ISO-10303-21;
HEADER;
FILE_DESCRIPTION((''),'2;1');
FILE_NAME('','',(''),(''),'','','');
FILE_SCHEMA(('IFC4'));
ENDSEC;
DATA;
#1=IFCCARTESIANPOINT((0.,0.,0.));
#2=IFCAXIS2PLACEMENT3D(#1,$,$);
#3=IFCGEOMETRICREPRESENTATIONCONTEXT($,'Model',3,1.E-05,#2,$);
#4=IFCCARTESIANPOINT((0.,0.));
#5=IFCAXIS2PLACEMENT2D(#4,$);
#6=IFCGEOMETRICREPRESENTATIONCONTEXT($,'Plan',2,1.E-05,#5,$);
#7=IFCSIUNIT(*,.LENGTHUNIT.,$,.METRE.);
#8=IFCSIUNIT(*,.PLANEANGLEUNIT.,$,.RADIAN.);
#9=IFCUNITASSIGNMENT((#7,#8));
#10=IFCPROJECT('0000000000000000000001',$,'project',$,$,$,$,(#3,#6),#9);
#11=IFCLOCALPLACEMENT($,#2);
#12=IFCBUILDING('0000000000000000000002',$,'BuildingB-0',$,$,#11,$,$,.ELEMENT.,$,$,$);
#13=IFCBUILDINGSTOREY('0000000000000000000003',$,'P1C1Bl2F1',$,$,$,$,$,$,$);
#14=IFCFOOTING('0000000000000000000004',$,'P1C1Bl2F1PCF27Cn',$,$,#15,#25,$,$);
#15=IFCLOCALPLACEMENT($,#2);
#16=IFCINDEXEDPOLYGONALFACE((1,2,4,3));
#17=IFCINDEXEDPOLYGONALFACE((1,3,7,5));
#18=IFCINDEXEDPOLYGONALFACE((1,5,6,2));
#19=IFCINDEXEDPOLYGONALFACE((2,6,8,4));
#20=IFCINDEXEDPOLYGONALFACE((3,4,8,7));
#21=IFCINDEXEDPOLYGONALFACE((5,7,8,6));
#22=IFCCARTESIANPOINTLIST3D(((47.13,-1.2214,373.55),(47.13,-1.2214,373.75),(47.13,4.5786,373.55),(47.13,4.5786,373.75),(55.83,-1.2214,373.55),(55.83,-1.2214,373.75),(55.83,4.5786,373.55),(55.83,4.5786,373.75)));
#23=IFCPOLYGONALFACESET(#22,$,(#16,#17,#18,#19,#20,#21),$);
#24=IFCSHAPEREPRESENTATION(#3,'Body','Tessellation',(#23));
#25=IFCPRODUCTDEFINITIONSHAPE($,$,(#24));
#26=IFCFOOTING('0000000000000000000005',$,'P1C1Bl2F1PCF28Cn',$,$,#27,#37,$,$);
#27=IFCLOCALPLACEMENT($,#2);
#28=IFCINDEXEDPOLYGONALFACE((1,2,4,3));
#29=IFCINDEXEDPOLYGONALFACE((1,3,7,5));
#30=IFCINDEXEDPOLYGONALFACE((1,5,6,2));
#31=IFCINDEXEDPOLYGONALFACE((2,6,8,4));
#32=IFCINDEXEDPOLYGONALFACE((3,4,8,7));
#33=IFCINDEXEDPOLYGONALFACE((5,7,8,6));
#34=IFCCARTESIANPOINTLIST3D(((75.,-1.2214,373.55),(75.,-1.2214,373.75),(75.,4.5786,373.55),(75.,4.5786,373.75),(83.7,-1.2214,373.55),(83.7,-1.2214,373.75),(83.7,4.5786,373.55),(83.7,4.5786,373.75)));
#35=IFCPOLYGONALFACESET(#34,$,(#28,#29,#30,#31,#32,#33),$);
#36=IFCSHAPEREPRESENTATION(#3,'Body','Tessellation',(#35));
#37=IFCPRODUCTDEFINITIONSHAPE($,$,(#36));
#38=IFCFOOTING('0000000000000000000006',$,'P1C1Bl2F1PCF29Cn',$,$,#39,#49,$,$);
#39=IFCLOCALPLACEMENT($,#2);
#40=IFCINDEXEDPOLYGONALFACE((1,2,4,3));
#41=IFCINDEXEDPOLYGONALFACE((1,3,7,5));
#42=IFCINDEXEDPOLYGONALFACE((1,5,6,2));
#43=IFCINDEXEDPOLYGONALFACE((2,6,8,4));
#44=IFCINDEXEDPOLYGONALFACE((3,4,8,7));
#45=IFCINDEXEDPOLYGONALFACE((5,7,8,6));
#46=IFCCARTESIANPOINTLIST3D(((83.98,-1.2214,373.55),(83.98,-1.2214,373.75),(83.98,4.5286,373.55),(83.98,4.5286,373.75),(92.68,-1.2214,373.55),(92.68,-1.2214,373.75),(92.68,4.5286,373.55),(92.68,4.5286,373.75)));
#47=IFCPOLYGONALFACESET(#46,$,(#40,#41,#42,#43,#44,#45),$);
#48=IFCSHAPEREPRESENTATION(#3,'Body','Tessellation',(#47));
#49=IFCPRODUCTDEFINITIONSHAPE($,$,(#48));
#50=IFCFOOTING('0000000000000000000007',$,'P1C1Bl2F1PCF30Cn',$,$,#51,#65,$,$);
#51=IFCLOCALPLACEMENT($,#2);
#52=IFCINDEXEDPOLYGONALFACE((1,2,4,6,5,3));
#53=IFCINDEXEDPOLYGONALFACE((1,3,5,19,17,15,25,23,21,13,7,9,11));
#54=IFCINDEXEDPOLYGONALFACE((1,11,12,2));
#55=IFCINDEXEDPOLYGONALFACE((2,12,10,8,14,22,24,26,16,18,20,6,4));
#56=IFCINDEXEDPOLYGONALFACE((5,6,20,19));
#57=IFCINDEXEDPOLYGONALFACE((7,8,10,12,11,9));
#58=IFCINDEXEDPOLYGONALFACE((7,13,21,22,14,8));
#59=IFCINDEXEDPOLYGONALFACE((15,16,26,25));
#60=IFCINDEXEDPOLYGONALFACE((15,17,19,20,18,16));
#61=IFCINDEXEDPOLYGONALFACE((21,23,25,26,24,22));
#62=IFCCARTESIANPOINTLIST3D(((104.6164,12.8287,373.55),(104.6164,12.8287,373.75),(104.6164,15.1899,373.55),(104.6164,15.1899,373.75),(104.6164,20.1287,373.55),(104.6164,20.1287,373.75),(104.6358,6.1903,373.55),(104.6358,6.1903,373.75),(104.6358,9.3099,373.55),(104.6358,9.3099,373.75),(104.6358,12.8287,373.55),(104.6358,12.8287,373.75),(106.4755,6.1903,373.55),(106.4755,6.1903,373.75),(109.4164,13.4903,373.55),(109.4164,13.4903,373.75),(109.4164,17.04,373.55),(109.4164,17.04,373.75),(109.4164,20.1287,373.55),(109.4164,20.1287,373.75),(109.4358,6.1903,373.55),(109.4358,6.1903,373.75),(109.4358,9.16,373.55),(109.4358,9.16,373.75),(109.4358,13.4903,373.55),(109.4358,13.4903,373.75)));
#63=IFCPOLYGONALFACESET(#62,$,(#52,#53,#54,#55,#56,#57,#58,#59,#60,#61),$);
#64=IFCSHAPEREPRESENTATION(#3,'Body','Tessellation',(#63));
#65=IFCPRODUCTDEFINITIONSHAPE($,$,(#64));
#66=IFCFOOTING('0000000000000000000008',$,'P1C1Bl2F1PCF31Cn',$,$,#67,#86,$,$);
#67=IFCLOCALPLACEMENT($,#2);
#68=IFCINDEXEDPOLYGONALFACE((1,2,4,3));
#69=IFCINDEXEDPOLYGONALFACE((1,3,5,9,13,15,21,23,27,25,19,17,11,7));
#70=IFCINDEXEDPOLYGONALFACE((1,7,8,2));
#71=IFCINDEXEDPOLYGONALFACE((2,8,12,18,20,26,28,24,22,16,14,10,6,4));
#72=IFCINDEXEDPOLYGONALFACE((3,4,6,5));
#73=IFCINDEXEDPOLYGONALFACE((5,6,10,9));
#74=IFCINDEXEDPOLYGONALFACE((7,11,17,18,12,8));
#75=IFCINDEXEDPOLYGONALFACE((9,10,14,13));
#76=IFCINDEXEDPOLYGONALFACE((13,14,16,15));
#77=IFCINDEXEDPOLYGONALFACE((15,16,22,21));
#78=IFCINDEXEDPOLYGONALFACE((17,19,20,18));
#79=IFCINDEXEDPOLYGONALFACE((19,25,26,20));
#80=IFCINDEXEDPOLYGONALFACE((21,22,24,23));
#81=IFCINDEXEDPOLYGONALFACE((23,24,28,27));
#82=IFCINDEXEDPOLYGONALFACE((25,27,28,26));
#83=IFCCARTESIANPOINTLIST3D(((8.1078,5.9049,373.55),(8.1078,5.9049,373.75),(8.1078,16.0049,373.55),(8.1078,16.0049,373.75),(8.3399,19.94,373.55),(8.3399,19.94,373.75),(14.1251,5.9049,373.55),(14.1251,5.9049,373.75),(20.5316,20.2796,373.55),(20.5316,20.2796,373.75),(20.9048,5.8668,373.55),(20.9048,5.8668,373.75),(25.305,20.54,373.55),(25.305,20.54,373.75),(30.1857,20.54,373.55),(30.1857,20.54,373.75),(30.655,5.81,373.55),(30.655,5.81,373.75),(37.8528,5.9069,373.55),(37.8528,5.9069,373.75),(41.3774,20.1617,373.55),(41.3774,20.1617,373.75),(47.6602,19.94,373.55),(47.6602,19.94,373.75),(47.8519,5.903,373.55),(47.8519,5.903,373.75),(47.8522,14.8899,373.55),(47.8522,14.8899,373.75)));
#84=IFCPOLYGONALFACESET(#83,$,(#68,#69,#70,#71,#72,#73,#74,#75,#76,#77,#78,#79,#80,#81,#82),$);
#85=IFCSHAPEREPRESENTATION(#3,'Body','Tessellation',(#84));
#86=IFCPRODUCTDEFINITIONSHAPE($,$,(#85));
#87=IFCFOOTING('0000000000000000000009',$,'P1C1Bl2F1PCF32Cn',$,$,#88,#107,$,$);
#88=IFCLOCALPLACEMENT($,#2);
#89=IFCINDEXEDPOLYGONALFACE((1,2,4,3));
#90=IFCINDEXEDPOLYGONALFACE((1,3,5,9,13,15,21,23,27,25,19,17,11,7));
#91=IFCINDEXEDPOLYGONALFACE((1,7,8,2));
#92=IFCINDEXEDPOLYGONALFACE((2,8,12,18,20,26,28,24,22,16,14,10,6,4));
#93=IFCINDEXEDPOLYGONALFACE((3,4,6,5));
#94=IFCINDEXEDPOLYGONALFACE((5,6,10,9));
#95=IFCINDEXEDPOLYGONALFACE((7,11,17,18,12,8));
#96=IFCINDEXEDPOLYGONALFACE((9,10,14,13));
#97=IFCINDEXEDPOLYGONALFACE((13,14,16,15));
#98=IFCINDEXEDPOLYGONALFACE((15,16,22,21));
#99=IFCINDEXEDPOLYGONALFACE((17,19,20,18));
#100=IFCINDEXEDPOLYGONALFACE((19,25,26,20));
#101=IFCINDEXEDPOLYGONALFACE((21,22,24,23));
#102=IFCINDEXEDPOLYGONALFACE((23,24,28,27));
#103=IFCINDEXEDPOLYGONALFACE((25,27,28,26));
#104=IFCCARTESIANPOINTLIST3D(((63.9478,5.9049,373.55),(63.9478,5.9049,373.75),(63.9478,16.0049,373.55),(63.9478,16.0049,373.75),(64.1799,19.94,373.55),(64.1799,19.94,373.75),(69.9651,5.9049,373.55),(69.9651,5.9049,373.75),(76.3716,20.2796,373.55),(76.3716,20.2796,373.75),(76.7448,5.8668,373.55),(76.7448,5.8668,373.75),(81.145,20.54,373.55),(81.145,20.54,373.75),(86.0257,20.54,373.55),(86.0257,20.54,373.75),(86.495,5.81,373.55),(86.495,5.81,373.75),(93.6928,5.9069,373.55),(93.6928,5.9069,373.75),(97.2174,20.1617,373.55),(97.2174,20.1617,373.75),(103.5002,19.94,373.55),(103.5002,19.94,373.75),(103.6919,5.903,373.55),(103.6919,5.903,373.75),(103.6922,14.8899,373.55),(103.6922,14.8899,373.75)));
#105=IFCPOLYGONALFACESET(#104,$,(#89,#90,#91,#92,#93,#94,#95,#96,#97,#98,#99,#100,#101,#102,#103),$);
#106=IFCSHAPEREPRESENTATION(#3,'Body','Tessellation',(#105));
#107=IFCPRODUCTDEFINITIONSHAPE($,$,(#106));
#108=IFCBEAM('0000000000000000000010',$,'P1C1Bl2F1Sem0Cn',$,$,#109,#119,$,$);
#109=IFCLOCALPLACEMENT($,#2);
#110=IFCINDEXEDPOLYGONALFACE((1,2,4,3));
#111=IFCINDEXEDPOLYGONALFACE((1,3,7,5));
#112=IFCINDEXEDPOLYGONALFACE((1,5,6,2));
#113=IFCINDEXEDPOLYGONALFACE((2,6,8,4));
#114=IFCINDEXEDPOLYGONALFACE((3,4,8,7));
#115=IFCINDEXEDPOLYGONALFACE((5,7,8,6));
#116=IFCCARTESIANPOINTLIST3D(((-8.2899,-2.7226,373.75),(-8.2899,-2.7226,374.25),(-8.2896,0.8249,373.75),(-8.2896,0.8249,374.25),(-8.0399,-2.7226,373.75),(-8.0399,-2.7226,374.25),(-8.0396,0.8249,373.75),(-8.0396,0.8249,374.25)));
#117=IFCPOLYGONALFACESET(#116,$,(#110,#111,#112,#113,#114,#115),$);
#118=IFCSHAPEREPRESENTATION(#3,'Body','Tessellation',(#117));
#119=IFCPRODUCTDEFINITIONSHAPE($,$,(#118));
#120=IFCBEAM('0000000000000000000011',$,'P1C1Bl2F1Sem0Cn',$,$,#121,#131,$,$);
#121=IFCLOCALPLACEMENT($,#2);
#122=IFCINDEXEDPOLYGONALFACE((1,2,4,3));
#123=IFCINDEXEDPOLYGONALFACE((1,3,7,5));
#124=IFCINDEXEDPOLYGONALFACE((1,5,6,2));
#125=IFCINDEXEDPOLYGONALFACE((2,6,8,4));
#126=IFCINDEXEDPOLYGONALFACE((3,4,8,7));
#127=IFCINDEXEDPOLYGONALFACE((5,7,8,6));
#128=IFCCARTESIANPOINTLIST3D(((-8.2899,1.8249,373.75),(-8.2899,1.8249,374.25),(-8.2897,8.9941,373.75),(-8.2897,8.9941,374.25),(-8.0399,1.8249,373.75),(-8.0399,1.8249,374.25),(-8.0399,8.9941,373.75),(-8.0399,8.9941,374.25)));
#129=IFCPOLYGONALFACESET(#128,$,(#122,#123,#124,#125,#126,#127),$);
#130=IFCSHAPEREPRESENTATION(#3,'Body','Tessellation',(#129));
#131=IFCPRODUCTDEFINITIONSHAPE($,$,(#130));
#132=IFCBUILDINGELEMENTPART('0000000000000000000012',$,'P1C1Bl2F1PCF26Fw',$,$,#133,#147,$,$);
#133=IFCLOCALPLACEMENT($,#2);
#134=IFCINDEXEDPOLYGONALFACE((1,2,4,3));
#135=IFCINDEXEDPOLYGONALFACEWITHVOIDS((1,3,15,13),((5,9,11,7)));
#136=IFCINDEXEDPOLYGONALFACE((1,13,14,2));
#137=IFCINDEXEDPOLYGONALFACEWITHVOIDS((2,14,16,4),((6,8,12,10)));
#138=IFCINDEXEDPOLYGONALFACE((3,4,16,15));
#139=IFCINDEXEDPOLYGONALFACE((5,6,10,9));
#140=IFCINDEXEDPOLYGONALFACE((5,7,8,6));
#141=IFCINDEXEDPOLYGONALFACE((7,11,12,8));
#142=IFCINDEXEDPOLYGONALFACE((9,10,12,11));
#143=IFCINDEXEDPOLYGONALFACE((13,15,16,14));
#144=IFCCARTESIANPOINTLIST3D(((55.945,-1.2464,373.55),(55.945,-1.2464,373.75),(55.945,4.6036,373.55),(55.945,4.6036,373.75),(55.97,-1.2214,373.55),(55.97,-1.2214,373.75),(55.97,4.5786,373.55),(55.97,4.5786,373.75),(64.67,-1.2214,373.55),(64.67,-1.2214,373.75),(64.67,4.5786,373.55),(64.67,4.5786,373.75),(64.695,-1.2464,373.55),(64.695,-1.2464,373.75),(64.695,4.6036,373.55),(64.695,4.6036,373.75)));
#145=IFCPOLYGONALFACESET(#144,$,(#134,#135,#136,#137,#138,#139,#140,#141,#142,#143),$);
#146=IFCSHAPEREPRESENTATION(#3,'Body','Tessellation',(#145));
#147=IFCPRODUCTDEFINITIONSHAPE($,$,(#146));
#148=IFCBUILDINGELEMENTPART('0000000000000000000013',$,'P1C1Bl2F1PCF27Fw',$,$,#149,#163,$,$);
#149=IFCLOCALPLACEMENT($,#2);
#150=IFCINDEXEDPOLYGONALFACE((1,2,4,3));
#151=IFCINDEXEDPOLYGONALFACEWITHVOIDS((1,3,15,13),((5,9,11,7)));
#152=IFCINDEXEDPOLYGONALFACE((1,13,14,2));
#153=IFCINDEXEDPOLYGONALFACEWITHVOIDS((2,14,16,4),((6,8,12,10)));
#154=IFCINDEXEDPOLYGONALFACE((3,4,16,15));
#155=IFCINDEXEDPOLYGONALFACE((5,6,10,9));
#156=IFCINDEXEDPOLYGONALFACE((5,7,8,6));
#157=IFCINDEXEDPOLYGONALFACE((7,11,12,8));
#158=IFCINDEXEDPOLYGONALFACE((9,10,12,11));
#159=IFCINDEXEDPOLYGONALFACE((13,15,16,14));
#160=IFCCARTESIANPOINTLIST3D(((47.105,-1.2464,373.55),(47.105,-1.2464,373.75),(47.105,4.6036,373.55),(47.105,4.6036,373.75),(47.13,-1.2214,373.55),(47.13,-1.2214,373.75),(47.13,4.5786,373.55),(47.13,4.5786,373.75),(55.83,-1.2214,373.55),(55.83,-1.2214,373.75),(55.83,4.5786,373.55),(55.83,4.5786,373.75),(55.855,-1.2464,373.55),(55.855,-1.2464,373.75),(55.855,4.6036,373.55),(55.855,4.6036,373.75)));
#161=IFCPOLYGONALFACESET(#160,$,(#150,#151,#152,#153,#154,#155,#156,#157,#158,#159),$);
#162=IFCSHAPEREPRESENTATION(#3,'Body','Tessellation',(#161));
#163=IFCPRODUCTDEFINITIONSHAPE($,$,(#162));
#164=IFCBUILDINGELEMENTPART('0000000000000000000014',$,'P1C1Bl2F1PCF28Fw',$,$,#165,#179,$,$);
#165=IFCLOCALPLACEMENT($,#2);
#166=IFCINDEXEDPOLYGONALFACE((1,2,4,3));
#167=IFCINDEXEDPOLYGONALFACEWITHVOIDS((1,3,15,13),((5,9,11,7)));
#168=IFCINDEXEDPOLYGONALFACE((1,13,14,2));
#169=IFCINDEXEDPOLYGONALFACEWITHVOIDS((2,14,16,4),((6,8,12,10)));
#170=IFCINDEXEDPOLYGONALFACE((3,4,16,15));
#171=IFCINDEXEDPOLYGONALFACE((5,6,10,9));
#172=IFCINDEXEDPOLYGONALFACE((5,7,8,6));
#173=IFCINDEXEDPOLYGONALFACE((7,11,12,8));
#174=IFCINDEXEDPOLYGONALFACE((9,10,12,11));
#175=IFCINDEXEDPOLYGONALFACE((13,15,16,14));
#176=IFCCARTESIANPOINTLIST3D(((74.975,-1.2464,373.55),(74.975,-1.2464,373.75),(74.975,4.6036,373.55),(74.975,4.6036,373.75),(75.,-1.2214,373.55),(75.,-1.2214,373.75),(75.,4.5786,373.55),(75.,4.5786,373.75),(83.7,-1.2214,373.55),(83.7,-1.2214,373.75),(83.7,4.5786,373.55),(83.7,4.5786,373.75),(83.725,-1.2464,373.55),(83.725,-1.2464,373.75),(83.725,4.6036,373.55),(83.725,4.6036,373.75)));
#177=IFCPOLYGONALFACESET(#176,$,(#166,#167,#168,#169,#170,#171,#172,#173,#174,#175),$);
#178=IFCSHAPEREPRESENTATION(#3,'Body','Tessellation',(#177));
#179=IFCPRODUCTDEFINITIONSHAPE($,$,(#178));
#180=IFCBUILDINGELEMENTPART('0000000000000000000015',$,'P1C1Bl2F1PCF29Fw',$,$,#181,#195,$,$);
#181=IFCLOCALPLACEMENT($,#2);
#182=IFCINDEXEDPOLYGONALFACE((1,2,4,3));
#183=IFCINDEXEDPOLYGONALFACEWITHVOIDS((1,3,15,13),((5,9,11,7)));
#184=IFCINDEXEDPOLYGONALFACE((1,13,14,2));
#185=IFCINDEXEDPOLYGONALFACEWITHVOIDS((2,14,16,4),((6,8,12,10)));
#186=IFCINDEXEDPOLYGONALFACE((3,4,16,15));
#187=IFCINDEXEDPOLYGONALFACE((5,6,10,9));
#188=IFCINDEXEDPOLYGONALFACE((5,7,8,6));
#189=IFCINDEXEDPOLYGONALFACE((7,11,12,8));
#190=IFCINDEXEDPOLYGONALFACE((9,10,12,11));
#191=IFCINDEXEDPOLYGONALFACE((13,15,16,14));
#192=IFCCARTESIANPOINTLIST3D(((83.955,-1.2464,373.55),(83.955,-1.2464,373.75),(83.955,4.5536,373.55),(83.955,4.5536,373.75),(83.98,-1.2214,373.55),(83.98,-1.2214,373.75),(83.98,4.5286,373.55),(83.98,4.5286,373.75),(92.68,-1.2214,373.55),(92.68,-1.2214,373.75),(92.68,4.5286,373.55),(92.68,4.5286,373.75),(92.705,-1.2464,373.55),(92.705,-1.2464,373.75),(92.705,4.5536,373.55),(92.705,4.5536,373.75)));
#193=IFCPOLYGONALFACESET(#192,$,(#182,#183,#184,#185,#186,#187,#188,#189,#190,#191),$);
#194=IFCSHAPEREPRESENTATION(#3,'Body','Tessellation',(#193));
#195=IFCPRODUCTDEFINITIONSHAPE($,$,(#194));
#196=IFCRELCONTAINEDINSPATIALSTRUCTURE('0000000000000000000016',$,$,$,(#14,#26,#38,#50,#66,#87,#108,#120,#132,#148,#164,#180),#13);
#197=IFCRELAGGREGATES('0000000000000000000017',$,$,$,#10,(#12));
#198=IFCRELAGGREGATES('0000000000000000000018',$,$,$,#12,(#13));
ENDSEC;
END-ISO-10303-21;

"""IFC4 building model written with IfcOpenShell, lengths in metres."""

from ifc_helpers import new_model, si_unit, origin, origin_2d, place, context, project, spatial, polyline, outline, extrude, element, save


model = new_model("IFC4")

# Units and contexts
model_context = context("Model", 3, precision=1e-05, world=origin())
plan_context = context("Plan", 2, precision=1e-05, world=origin_2d())
ifc_project = project(units=[si_unit("LENGTHUNIT", "METRE"), si_unit("PLANEANGLEUNIT", "RADIAN")], contexts=[model_context, plan_context])

# Building, storey
building_placement = place(None, origin())
building = spatial("IfcBuilding", under=ifc_project, at=building_placement, Name="BuildingB-0", CompositionType="ELEMENT")
storey = spatial("IfcBuildingStorey", under=building, Name="P1C1Bl2F1")

# Footings
element("IfcFooting", 1, inside=storey, Name="P1C1Bl2F1PCF27Cn", context=model_context, shape_type="SweptSolid", body=[
    extrude(outline(polyline([(47.13, -1.2214, 373.55), (55.83, -1.2214, 373.55), (55.83, 4.5786, 373.55), (47.13, 4.5786, 373.55), (47.13, -1.2214, 373.55)])), None, (0.0, 0.0, 1.0), 0.2),
])
element("IfcFooting", 2, inside=storey, Name="P1C1Bl2F1PCF28Cn", context=model_context, shape_type="SweptSolid", body=[
    extrude(outline(polyline([(75.0, -1.2214, 373.55), (83.7, -1.2214, 373.55), (83.7, 4.5786, 373.55), (75.0, 4.5786, 373.55), (75.0, -1.2214, 373.55)])), None, (0.0, 0.0, 1.0), 0.2),
])
element("IfcFooting", 3, inside=storey, Name="P1C1Bl2F1PCF29Cn", context=model_context, shape_type="SweptSolid", body=[
    extrude(outline(polyline([(92.68, -1.2214, 373.55), (83.98, -1.2214, 373.55), (83.98, 4.5286, 373.55), (92.68, 4.5286, 373.55), (92.68, -1.2214, 373.55)])), None, (0.0, 0.0, 1.0), 0.2),
])
element("IfcFooting", 4, inside=storey, Name="P1C1Bl2F1PCF30Cn", context=model_context, shape_type="SweptSolid", body=[
    extrude(outline(polyline([(104.6358, 12.8287, 373.55), (104.6164, 12.8287, 373.55), (104.6164, 15.1899, 373.55), (104.6164, 20.1287, 373.55), (109.4164, 20.1287, 373.55), (109.4164, 17.04, 373.55), (109.4164, 13.4903, 373.55), (109.4358, 13.4903, 373.55), (109.4358, 9.16, 373.55), (109.4358, 6.1903, 373.55), (106.4755, 6.1903, 373.55), (104.6358, 6.1903, 373.55), (104.6358, 9.3099, 373.55), (104.6358, 12.8287, 373.55)])), None, (0.0, 0.0, 1.0), 0.2),
])
element("IfcFooting", 5, inside=storey, Name="P1C1Bl2F1PCF31Cn", context=model_context, shape_type="SweptSolid", body=[
    extrude(outline(polyline([(8.3399, 19.94, 373.55), (20.5316, 20.2796, 373.55), (25.305, 20.54, 373.55), (30.1857, 20.54, 373.55), (41.3774, 20.1617, 373.55), (47.6602, 19.94, 373.55), (47.8522, 14.8899, 373.55), (47.8519, 5.903, 373.55), (37.8528, 5.9069, 373.55), (30.655, 5.81, 373.55), (20.9048, 5.8668, 373.55), (14.1251, 5.9049, 373.55), (8.1078, 5.9049, 373.55), (8.1078, 16.0049, 373.55), (8.3399, 19.94, 373.55)])), None, (0.0, 0.0, 1.0), 0.2),
])
element("IfcFooting", 6, inside=storey, Name="P1C1Bl2F1PCF32Cn", context=model_context, shape_type="SweptSolid", body=[
    extrude(outline(polyline([(64.1799, 19.94, 373.55), (76.3716, 20.2796, 373.55), (81.145, 20.54, 373.55), (86.0257, 20.54, 373.55), (97.2174, 20.1617, 373.55), (103.5002, 19.94, 373.55), (103.6922, 14.8899, 373.55), (103.6919, 5.903, 373.55), (93.6928, 5.9069, 373.55), (86.495, 5.81, 373.55), (76.7448, 5.8668, 373.55), (69.9651, 5.9049, 373.55), (63.9478, 5.9049, 373.55), (63.9478, 16.0049, 373.55), (64.1799, 19.94, 373.55)])), None, (0.0, 0.0, 1.0), 0.2),
])

# Beams
element("IfcBeam", 7, inside=storey, Name="P1C1Bl2F1Sem0Cn", context=model_context, shape_type="SweptSolid", body=[
    extrude(outline(polyline([(-8.2899, -2.7226, 373.75), (-8.0399, -2.7226, 373.75), (-8.0396, 0.8249, 373.75), (-8.2896, 0.8249, 373.75), (-8.2899, -2.7226, 373.75)])), None, (0.0, 0.0, 1.0), 0.5),
])
element("IfcBeam", 8, inside=storey, Name="P1C1Bl2F1Sem0Cn", context=model_context, shape_type="SweptSolid", body=[
    extrude(outline(polyline([(-8.2899, 1.8249, 373.75), (-8.0399, 1.8249, 373.75), (-8.0399, 8.9941, 373.75), (-8.2897, 8.9941, 373.75), (-8.2899, 1.8249, 373.75)])), None, (0.0, 0.0, 1.0), 0.5),
])

# Building element parts, openings
building_element_part_1 = element("IfcBuildingElementPart", 9, inside=storey, Name="P1C1Bl2F1PCF26Fw", context=model_context, shape_type="SweptSolid", body=[
    extrude(outline(polyline([(55.945, -1.2464, 373.55), (64.695, -1.2464, 373.55), (64.695, 4.6036, 373.55), (55.945, 4.6036, 373.55), (55.945, -1.2464, 373.55)])), None, (0.0, 0.0, 1.0), 0.2),
])
element("IfcOpeningElement", 10, inside=storey, cuts=building_element_part_1, context=model_context, shape_type="SweptSolid", body=[
    extrude(outline(polyline([(55.97, -1.2214, 373.55), (64.67, -1.2214, 373.55), (64.67, 4.5786, 373.55), (55.97, 4.5786, 373.55), (55.97, -1.2214, 373.55)])), None, (0.0, 0.0, 1.0), 0.2),
])
building_element_part_2 = element("IfcBuildingElementPart", 11, inside=storey, Name="P1C1Bl2F1PCF27Fw", context=model_context, shape_type="SweptSolid", body=[
    extrude(outline(polyline([(47.105, -1.2464, 373.55), (55.855, -1.2464, 373.55), (55.855, 4.6036, 373.55), (47.105, 4.6036, 373.55), (47.105, -1.2464, 373.55)])), None, (0.0, 0.0, 1.0), 0.2),
])
element("IfcOpeningElement", 12, inside=storey, cuts=building_element_part_2, context=model_context, shape_type="SweptSolid", body=[
    extrude(outline(polyline([(47.13, -1.2214, 373.55), (55.83, -1.2214, 373.55), (55.83, 4.5786, 373.55), (47.13, 4.5786, 373.55), (47.13, -1.2214, 373.55)])), None, (0.0, 0.0, 1.0), 0.2),
])
building_element_part_3 = element("IfcBuildingElementPart", 13, inside=storey, Name="P1C1Bl2F1PCF28Fw", context=model_context, shape_type="SweptSolid", body=[
    extrude(outline(polyline([(74.975, -1.2464, 373.55), (83.725, -1.2464, 373.55), (83.725, 4.6036, 373.55), (74.975, 4.6036, 373.55), (74.975, -1.2464, 373.55)])), None, (0.0, 0.0, 1.0), 0.2),
])
element("IfcOpeningElement", 14, inside=storey, cuts=building_element_part_3, context=model_context, shape_type="SweptSolid", body=[
    extrude(outline(polyline([(75.0, -1.2214, 373.55), (83.7, -1.2214, 373.55), (83.7, 4.5786, 373.55), (75.0, 4.5786, 373.55), (75.0, -1.2214, 373.55)])), None, (0.0, 0.0, 1.0), 0.2),
])
building_element_part_4 = element("IfcBuildingElementPart", 15, inside=storey, Name="P1C1Bl2F1PCF29Fw", context=model_context, shape_type="SweptSolid", body=[
    extrude(outline(polyline([(92.705, -1.2464, 373.55), (83.955, -1.2464, 373.55), (83.955, 4.5536, 373.55), (92.705, 4.5536, 373.55), (92.705, -1.2464, 373.55)])), None, (0.0, 0.0, 1.0), 0.2),
])
element("IfcOpeningElement", 16, inside=storey, cuts=building_element_part_4, context=model_context, shape_type="SweptSolid", body=[
    extrude(outline(polyline([(92.68, -1.2214, 373.55), (83.98, -1.2214, 373.55), (83.98, 4.5286, 373.55), (92.68, 4.5286, 373.55), (92.68, -1.2214, 373.55)])), None, (0.0, 0.0, 1.0), 0.2),
])

save(model, "model.ifc")
